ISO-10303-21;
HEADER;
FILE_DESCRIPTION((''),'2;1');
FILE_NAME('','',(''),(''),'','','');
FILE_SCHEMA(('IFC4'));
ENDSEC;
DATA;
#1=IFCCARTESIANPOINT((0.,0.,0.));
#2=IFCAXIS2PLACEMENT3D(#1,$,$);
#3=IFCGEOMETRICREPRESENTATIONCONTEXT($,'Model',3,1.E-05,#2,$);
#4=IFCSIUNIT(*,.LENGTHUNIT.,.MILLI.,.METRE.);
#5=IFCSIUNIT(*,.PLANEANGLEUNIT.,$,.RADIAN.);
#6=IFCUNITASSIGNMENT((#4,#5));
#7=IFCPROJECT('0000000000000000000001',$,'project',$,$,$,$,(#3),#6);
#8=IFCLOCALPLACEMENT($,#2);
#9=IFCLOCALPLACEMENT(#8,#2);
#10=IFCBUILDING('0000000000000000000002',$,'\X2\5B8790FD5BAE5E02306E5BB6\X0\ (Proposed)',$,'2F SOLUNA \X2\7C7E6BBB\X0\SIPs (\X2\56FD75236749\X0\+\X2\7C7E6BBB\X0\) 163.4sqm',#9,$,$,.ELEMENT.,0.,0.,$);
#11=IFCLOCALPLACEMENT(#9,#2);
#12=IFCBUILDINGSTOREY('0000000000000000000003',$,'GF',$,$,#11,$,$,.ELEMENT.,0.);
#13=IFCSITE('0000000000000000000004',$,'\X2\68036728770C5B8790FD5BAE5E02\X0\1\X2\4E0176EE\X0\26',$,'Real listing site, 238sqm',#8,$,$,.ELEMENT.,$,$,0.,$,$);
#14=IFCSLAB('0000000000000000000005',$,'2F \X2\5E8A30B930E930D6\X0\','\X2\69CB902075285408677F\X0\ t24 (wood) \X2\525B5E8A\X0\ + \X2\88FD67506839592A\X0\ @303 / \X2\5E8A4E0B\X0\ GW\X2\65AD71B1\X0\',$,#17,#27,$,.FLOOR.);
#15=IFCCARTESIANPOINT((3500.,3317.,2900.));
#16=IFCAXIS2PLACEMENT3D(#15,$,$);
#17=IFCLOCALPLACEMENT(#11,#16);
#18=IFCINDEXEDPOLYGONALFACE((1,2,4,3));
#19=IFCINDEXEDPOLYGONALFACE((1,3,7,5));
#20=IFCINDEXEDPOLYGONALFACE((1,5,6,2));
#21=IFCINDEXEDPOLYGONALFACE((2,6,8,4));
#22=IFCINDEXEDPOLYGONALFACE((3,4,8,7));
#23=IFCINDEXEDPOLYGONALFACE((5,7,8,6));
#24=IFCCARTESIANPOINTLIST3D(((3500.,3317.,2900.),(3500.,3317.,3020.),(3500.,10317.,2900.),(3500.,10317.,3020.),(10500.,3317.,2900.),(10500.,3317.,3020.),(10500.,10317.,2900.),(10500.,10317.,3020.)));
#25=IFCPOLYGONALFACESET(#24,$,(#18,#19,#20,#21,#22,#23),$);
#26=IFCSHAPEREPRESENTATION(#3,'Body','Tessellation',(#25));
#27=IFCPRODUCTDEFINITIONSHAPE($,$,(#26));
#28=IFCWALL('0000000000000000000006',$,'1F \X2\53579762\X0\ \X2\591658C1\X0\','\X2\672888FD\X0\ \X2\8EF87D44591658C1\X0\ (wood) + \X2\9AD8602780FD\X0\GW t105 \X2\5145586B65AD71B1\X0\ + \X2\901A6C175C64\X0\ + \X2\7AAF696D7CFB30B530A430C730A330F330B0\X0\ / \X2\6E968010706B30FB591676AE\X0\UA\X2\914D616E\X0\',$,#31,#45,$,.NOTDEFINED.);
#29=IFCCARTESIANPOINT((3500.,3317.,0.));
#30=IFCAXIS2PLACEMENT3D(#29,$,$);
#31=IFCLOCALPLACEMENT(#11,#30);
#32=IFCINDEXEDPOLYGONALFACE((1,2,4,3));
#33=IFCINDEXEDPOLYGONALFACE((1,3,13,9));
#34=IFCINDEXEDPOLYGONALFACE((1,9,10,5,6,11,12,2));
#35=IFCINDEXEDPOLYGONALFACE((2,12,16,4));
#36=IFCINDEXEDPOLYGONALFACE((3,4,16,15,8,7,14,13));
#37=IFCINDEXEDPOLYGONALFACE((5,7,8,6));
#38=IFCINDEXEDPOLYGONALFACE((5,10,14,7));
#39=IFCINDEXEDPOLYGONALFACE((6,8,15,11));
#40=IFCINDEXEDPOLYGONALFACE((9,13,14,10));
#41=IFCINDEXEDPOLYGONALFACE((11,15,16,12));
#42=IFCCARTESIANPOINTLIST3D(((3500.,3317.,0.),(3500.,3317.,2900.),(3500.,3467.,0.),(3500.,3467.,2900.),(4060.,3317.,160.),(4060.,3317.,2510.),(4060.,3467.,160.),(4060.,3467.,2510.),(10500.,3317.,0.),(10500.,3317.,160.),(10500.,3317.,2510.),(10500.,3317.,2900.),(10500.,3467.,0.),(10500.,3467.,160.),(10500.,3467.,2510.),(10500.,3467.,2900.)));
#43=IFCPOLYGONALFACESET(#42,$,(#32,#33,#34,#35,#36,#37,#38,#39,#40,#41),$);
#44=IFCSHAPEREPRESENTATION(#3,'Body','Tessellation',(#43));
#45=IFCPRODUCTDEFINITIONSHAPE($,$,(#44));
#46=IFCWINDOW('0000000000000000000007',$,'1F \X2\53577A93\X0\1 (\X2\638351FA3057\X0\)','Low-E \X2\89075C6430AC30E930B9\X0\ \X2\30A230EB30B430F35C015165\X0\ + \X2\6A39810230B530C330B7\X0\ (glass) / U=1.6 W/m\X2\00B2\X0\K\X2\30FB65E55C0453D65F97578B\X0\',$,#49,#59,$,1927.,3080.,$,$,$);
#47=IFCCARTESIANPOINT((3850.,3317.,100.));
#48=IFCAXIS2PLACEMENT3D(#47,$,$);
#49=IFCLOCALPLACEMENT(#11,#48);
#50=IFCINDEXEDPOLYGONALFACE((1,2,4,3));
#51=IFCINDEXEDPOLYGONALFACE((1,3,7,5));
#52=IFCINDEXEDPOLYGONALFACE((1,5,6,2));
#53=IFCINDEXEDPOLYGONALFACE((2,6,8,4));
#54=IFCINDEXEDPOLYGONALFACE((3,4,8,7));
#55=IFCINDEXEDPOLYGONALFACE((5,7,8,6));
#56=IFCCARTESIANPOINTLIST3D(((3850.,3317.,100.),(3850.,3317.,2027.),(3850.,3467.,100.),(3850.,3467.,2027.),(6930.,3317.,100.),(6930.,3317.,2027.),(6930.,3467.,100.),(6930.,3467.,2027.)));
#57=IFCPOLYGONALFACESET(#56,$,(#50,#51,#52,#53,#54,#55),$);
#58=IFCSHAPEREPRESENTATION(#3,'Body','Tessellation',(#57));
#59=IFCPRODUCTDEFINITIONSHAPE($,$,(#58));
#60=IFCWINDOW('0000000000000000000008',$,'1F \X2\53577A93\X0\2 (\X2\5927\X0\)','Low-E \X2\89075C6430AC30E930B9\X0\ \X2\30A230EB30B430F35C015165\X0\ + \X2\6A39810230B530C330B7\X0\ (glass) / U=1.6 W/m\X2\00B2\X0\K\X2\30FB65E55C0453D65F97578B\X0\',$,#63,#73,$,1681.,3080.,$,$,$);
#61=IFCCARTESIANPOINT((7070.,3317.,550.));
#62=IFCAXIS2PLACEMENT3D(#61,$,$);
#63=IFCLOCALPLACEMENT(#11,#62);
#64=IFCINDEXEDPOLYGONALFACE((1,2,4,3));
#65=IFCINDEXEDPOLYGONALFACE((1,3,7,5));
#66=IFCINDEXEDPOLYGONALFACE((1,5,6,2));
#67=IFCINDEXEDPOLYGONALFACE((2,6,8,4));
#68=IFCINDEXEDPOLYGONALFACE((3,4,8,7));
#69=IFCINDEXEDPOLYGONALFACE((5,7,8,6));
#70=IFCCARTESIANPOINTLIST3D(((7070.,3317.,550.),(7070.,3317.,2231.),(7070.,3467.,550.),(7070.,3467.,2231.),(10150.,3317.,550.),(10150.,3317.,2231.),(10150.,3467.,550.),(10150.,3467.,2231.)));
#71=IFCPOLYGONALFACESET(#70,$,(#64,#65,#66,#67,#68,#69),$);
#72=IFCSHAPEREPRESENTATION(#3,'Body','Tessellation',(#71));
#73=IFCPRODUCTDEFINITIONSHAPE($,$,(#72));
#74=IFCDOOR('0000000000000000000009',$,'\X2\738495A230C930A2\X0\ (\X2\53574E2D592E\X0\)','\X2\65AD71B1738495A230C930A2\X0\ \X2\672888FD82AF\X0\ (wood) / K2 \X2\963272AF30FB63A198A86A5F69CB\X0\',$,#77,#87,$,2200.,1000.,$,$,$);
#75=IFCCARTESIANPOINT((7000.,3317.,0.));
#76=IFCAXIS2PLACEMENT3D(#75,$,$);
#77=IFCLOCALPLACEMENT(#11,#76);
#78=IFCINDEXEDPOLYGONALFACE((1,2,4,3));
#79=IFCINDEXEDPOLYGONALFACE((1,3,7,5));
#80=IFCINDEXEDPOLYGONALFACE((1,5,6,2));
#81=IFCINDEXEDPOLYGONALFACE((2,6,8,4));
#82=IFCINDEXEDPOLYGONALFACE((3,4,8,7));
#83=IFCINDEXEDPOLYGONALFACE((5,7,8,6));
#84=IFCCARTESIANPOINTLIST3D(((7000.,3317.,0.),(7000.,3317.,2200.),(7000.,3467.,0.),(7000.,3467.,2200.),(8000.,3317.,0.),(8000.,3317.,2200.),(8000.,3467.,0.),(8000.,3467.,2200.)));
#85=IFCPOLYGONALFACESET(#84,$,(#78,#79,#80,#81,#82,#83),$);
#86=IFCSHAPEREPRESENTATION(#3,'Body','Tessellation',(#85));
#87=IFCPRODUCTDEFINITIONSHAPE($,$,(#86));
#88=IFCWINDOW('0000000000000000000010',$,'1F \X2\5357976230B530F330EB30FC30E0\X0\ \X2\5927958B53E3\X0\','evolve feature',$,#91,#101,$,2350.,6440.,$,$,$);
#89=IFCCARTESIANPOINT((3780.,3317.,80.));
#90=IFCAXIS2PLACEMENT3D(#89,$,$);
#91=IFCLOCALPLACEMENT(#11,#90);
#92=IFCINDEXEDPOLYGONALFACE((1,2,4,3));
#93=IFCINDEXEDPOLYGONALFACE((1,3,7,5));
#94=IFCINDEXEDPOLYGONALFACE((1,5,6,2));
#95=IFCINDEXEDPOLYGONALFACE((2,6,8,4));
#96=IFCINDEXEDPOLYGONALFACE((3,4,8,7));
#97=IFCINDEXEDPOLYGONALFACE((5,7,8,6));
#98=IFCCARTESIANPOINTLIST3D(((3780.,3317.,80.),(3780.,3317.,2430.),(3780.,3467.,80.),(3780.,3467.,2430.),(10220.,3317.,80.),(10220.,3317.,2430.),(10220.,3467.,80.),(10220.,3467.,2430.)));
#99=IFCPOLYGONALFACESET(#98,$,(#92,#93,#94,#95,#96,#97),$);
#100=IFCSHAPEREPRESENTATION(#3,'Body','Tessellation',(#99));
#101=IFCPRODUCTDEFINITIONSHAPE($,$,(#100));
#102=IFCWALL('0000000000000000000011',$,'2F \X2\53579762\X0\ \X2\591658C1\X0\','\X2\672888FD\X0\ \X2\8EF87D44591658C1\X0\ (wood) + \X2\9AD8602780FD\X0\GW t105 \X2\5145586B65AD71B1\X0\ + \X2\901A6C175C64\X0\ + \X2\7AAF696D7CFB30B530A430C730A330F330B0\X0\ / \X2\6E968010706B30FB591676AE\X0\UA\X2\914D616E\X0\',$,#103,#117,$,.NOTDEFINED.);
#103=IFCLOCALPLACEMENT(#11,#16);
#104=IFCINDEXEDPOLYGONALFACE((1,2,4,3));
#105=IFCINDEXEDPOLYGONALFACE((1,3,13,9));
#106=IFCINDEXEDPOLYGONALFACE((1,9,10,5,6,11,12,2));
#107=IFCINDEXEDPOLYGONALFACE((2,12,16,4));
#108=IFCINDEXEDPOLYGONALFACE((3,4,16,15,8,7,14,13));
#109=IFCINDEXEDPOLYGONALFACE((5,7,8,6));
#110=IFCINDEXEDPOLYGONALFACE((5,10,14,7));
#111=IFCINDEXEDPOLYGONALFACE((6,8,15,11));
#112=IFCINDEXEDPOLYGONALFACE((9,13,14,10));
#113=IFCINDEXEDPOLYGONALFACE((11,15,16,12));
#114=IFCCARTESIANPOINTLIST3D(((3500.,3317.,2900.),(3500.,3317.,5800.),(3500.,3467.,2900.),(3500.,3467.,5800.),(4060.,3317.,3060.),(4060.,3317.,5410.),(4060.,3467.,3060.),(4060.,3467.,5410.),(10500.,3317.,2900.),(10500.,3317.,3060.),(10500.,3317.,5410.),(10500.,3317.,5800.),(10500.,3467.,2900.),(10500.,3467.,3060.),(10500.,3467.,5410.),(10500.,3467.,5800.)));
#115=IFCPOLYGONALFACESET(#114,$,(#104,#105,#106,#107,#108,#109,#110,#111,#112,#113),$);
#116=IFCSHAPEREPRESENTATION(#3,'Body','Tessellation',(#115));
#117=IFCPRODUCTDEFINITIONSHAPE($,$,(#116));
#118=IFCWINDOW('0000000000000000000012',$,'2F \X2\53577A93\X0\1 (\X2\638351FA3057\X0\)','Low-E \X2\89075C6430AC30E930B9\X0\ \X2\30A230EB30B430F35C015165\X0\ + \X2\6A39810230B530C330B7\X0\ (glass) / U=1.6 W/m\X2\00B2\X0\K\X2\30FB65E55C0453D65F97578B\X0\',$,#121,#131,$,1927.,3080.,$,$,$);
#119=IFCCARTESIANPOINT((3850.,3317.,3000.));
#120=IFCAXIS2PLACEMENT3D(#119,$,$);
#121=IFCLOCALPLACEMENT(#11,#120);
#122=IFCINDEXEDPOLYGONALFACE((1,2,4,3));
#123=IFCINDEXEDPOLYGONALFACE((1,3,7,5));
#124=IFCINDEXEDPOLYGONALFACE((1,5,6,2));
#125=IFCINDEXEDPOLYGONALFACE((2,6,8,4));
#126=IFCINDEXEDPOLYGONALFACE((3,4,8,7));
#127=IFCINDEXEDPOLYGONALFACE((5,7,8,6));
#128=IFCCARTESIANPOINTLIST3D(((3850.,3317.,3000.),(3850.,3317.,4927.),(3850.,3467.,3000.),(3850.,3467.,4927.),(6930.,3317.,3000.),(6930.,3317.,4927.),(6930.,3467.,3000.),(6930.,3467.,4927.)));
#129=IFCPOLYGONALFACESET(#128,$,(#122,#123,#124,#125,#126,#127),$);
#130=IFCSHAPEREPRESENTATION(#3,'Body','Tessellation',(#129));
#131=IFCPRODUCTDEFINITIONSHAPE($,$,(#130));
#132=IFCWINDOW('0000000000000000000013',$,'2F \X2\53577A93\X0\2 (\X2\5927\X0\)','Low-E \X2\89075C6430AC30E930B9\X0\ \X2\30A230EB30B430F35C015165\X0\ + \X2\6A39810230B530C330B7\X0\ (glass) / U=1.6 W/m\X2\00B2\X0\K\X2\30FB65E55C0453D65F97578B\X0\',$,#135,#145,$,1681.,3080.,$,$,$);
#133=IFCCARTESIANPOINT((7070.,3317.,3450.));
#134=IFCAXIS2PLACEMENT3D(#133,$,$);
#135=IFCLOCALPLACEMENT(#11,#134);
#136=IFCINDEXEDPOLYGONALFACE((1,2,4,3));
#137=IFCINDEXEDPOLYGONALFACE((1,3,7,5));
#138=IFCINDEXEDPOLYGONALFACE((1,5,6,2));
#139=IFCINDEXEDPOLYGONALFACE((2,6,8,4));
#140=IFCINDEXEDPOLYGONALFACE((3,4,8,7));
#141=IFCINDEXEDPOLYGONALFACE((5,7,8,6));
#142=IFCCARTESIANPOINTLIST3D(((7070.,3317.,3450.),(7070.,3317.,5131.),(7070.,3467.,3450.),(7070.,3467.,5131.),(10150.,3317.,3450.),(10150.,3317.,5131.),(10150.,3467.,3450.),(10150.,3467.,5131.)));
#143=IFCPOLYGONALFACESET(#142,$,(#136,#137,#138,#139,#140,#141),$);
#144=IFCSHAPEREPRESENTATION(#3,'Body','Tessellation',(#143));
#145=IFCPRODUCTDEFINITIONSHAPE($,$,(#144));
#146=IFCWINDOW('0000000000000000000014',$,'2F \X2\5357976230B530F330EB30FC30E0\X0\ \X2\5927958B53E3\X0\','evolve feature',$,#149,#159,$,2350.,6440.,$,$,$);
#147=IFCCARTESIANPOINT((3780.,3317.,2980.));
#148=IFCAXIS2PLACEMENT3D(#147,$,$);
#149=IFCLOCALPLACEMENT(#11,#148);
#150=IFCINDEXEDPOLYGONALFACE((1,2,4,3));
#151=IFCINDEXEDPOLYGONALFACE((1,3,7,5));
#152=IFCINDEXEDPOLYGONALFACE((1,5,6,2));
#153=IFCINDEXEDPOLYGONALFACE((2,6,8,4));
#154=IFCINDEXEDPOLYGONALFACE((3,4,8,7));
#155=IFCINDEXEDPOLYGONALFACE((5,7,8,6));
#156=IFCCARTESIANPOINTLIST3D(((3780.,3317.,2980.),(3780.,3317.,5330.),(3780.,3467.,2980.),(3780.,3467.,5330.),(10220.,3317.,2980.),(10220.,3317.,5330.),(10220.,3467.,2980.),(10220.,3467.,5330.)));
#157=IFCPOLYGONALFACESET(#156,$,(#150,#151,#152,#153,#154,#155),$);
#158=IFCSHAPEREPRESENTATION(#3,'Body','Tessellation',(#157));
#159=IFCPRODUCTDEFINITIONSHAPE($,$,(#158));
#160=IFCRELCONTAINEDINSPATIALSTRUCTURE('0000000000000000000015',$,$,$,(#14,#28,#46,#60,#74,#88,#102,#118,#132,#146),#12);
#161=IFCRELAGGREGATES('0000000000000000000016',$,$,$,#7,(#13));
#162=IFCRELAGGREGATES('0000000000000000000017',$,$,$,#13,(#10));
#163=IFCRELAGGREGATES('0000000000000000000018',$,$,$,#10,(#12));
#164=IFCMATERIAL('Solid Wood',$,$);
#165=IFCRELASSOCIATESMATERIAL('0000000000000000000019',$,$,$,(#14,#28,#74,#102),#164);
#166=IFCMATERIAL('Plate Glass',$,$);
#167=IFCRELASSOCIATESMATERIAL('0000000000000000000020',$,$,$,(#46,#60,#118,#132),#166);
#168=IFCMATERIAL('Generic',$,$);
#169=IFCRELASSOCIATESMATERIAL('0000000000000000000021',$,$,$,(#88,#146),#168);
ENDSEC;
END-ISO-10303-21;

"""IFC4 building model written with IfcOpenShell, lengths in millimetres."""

from ifc_helpers import new_model, si_unit, frame, frame_2d, origin, place, context, project, spatial, rectangle, extrude, material, element, fill, save


model = new_model("IFC4")

# Units and contexts
model_context = context("Model", 3, precision=1e-05, world=origin())
ifc_project = project(units=[si_unit("LENGTHUNIT", "METRE", prefix="MILLI"), si_unit("PLANEANGLEUNIT", "RADIAN")], contexts=[model_context])

# Site, building, storey
site_placement = place(None, origin())
site = spatial("IfcSite", under=ifc_project, at=site_placement, Name="栃木県宇都宮市1丁目26", ObjectType="Real listing site, 238sqm", CompositionType="ELEMENT", RefElevation=0.0)
building_placement = place(site_placement, origin())
building = spatial("IfcBuilding", under=site, at=building_placement, Name="宇都宮市の家 (Proposed)", ObjectType="2F SOLUNA 籾殻SIPs (国産杉+籾殻) 163.4sqm", CompositionType="ELEMENT", ElevationOfRefHeight=0.0, ElevationOfTerrain=0.0)
storey_placement = place(building_placement, origin())
storey = spatial("IfcBuildingStorey", under=building, at=storey_placement, Name="GF", CompositionType="ELEMENT", Elevation=0.0)

# Slab
ifc_material_1 = material(Name="Solid Wood")
slab_1_placement = place(storey_placement, frame((3500.0, 3317.0, 2900.0)))
element("IfcSlab", 1, at=slab_1_placement, inside=storey, material=ifc_material_1, Name="2F 床スラブ", Description="構造用合板 t24 (wood) 剛床 + 製材根太 @303 / 床下 GW断熱", PredefinedType="FLOOR", context=model_context, shape_type="SweptSolid", body=[
    extrude(rectangle(XDim=7000.0, YDim=7000.0, at=frame_2d((3500.0, 3500.0))), frame((3500.0, 3317.0, 2900.0)), (0.0, 0.0, 1.0), 120.0),
])
ifc_material_2 = material(Name="Generic")

# Wall, openings, windows, door
wall_1_placement = place(storey_placement, frame((3500.0, 3317.0, 0.0)))
wall_1 = element("IfcWall", 2, at=wall_1_placement, inside=storey, material=ifc_material_1, Name="1F 南面 外壁", Description="木製 軸組外壁 (wood) + 高性能GW t105 充填断熱 + 通気層 + 窯業系サイディング / 準耐火・外皮UA配慮", PredefinedType="NOTDEFINED", context=model_context, shape_type="SweptSolid", body=[
    extrude(rectangle(XDim=7000.0, YDim=150.0, at=frame_2d((3500.0, 75.0))), frame((3500.0, 3317.0, 0.0)), (0.0, 0.0, 1.0), 2900.0),
])
opening_1_placement = place(storey_placement, frame((3850.0, 3317.0, 100.0)))
opening_1 = element("IfcOpeningElement", 3, at=opening_1_placement, cuts=wall_1, PredefinedType="NOTDEFINED", context=model_context, shape_type="SweptSolid", body=[
    extrude(rectangle(XDim=3080.0, YDim=150.0, at=frame_2d((1540.0, 75.0))), frame((3850.0, 3317.0, 100.0)), (0.0, 0.0, 1.0), 1927.0),
])
opening_2_placement = place(storey_placement, frame((7070.0, 3317.0, 550.0)))
opening_2 = element("IfcOpeningElement", 4, at=opening_2_placement, cuts=wall_1, PredefinedType="NOTDEFINED", context=model_context, shape_type="SweptSolid", body=[
    extrude(rectangle(XDim=3080.0, YDim=150.0, at=frame_2d((1540.0, 75.0))), frame((7070.0, 3317.0, 550.0)), (0.0, 0.0, 1.0), 1681.0),
])
opening_3_placement = place(storey_placement, frame((7000.0, 3317.0, 0.0)))
opening_3 = element("IfcOpeningElement", 5, at=opening_3_placement, cuts=wall_1, PredefinedType="NOTDEFINED", context=model_context, shape_type="SweptSolid", body=[
    extrude(rectangle(XDim=1000.0, YDim=150.0, at=frame_2d((500.0, 75.0))), frame((7000.0, 3317.0, 0.0)), (0.0, 0.0, 1.0), 2200.0),
])
opening_4_placement = place(storey_placement, frame((3780.0, 3317.0, 80.0)))
opening_4 = element("IfcOpeningElement", 6, at=opening_4_placement, cuts=wall_1, PredefinedType="NOTDEFINED", context=model_context, shape_type="SweptSolid", body=[
    extrude(rectangle(XDim=6440.0, YDim=150.0, at=frame_2d((3220.0, 75.0))), frame((3780.0, 3317.0, 80.0)), (0.0, 0.0, 1.0), 2350.0),
])
ifc_material_3 = material(Name="Plate Glass")
window_1_placement = place(storey_placement, frame((3850.0, 3317.0, 100.0)))
window_1 = element("IfcWindow", 7, at=window_1_placement, inside=storey, material=ifc_material_3, Name="1F 南窓1 (掃出し)", Description="Low-E 複層ガラス アルゴン封入 + 樹脂サッシ (glass) / U=1.6 W/m²K・日射取得型", OverallHeight=1927.0, OverallWidth=3080.0, context=model_context, shape_type="SweptSolid", body=[
    extrude(rectangle(XDim=3080.0, YDim=150.0, at=frame_2d((1540.0, 75.0))), frame((3850.0, 3317.0, 100.0)), (0.0, 0.0, 1.0), 1927.0),
])
fill(opening_1, window_1)
window_2_placement = place(storey_placement, frame((7070.0, 3317.0, 550.0)))
window_2 = element("IfcWindow", 8, at=window_2_placement, inside=storey, material=ifc_material_3, Name="1F 南窓2 (大)", Description="Low-E 複層ガラス アルゴン封入 + 樹脂サッシ (glass) / U=1.6 W/m²K・日射取得型", OverallHeight=1681.0, OverallWidth=3080.0, context=model_context, shape_type="SweptSolid", body=[
    extrude(rectangle(XDim=3080.0, YDim=150.0, at=frame_2d((1540.0, 75.0))), frame((7070.0, 3317.0, 550.0)), (0.0, 0.0, 1.0), 1681.0),
])
fill(opening_2, window_2)
door_placement = place(storey_placement, frame((7000.0, 3317.0, 0.0)))
door = element("IfcDoor", 9, at=door_placement, inside=storey, material=ifc_material_1, Name="玄関ドア (南中央)", Description="断熱玄関ドア 木製芯 (wood) / K2 防犯・採風機構", OverallHeight=2200.0, OverallWidth=1000.0, context=model_context, shape_type="SweptSolid", body=[
    extrude(rectangle(XDim=1000.0, YDim=150.0, at=frame_2d((500.0, 75.0))), frame((7000.0, 3317.0, 0.0)), (0.0, 0.0, 1.0), 2200.0),
])
fill(opening_3, door)
window_3_placement = place(storey_placement, frame((3780.0, 3317.0, 80.0)))
window_3 = element("IfcWindow", 10, at=window_3_placement, inside=storey, material=ifc_material_2, Name="1F 南面サンルーム 大開口", Description="evolve feature", OverallHeight=2350.0, OverallWidth=6440.0, context=model_context, shape_type="SweptSolid", body=[
    extrude(rectangle(XDim=6440.0, YDim=150.0, at=frame_2d((3220.0, 75.0))), frame((3780.0, 3317.0, 80.0)), (0.0, 0.0, 1.0), 2350.0),
])
fill(opening_4, window_3)

# Wall, openings, windows
wall_2_placement = place(storey_placement, frame((3500.0, 3317.0, 2900.0)))
wall_2 = element("IfcWall", 11, at=wall_2_placement, inside=storey, material=ifc_material_1, Name="2F 南面 外壁", Description="木製 軸組外壁 (wood) + 高性能GW t105 充填断熱 + 通気層 + 窯業系サイディング / 準耐火・外皮UA配慮", PredefinedType="NOTDEFINED", context=model_context, shape_type="SweptSolid", body=[
    extrude(rectangle(XDim=7000.0, YDim=150.0, at=frame_2d((3500.0, 75.0))), frame((3500.0, 3317.0, 2900.0)), (0.0, 0.0, 1.0), 2900.0),
])
opening_5_placement = place(storey_placement, frame((3850.0, 3317.0, 3000.0)))
opening_5 = element("IfcOpeningElement", 12, at=opening_5_placement, cuts=wall_2, PredefinedType="NOTDEFINED", context=model_context, shape_type="SweptSolid", body=[
    extrude(rectangle(XDim=3080.0, YDim=150.0, at=frame_2d((1540.0, 75.0))), frame((3850.0, 3317.0, 3000.0)), (0.0, 0.0, 1.0), 1927.0),
])
opening_6_placement = place(storey_placement, frame((7070.0, 3317.0, 3450.0)))
opening_6 = element("IfcOpeningElement", 13, at=opening_6_placement, cuts=wall_2, PredefinedType="NOTDEFINED", context=model_context, shape_type="SweptSolid", body=[
    extrude(rectangle(XDim=3080.0, YDim=150.0, at=frame_2d((1540.0, 75.0))), frame((7070.0, 3317.0, 3450.0)), (0.0, 0.0, 1.0), 1681.0),
])
opening_7_placement = place(storey_placement, frame((3780.0, 3317.0, 2980.0)))
opening_7 = element("IfcOpeningElement", 14, at=opening_7_placement, cuts=wall_2, PredefinedType="NOTDEFINED", context=model_context, shape_type="SweptSolid", body=[
    extrude(rectangle(XDim=6440.0, YDim=150.0, at=frame_2d((3220.0, 75.0))), frame((3780.0, 3317.0, 2980.0)), (0.0, 0.0, 1.0), 2350.0),
])
window_4_placement = place(storey_placement, frame((3850.0, 3317.0, 3000.0)))
window_4 = element("IfcWindow", 15, at=window_4_placement, inside=storey, material=ifc_material_3, Name="2F 南窓1 (掃出し)", Description="Low-E 複層ガラス アルゴン封入 + 樹脂サッシ (glass) / U=1.6 W/m²K・日射取得型", OverallHeight=1927.0, OverallWidth=3080.0, context=model_context, shape_type="SweptSolid", body=[
    extrude(rectangle(XDim=3080.0, YDim=150.0, at=frame_2d((1540.0, 75.0))), frame((3850.0, 3317.0, 3000.0)), (0.0, 0.0, 1.0), 1927.0),
])
fill(opening_5, window_4)
window_5_placement = place(storey_placement, frame((7070.0, 3317.0, 3450.0)))
window_5 = element("IfcWindow", 16, at=window_5_placement, inside=storey, material=ifc_material_3, Name="2F 南窓2 (大)", Description="Low-E 複層ガラス アルゴン封入 + 樹脂サッシ (glass) / U=1.6 W/m²K・日射取得型", OverallHeight=1681.0, OverallWidth=3080.0, context=model_context, shape_type="SweptSolid", body=[
    extrude(rectangle(XDim=3080.0, YDim=150.0, at=frame_2d((1540.0, 75.0))), frame((7070.0, 3317.0, 3450.0)), (0.0, 0.0, 1.0), 1681.0),
])
fill(opening_6, window_5)
window_6_placement = place(storey_placement, frame((3780.0, 3317.0, 2980.0)))
window_6 = element("IfcWindow", 17, at=window_6_placement, inside=storey, material=ifc_material_2, Name="2F 南面サンルーム 大開口", Description="evolve feature", OverallHeight=2350.0, OverallWidth=6440.0, context=model_context, shape_type="SweptSolid", body=[
    extrude(rectangle(XDim=6440.0, YDim=150.0, at=frame_2d((3220.0, 75.0))), frame((3780.0, 3317.0, 2980.0)), (0.0, 0.0, 1.0), 2350.0),
])
fill(opening_7, window_6)

save(model, "model.ifc")
